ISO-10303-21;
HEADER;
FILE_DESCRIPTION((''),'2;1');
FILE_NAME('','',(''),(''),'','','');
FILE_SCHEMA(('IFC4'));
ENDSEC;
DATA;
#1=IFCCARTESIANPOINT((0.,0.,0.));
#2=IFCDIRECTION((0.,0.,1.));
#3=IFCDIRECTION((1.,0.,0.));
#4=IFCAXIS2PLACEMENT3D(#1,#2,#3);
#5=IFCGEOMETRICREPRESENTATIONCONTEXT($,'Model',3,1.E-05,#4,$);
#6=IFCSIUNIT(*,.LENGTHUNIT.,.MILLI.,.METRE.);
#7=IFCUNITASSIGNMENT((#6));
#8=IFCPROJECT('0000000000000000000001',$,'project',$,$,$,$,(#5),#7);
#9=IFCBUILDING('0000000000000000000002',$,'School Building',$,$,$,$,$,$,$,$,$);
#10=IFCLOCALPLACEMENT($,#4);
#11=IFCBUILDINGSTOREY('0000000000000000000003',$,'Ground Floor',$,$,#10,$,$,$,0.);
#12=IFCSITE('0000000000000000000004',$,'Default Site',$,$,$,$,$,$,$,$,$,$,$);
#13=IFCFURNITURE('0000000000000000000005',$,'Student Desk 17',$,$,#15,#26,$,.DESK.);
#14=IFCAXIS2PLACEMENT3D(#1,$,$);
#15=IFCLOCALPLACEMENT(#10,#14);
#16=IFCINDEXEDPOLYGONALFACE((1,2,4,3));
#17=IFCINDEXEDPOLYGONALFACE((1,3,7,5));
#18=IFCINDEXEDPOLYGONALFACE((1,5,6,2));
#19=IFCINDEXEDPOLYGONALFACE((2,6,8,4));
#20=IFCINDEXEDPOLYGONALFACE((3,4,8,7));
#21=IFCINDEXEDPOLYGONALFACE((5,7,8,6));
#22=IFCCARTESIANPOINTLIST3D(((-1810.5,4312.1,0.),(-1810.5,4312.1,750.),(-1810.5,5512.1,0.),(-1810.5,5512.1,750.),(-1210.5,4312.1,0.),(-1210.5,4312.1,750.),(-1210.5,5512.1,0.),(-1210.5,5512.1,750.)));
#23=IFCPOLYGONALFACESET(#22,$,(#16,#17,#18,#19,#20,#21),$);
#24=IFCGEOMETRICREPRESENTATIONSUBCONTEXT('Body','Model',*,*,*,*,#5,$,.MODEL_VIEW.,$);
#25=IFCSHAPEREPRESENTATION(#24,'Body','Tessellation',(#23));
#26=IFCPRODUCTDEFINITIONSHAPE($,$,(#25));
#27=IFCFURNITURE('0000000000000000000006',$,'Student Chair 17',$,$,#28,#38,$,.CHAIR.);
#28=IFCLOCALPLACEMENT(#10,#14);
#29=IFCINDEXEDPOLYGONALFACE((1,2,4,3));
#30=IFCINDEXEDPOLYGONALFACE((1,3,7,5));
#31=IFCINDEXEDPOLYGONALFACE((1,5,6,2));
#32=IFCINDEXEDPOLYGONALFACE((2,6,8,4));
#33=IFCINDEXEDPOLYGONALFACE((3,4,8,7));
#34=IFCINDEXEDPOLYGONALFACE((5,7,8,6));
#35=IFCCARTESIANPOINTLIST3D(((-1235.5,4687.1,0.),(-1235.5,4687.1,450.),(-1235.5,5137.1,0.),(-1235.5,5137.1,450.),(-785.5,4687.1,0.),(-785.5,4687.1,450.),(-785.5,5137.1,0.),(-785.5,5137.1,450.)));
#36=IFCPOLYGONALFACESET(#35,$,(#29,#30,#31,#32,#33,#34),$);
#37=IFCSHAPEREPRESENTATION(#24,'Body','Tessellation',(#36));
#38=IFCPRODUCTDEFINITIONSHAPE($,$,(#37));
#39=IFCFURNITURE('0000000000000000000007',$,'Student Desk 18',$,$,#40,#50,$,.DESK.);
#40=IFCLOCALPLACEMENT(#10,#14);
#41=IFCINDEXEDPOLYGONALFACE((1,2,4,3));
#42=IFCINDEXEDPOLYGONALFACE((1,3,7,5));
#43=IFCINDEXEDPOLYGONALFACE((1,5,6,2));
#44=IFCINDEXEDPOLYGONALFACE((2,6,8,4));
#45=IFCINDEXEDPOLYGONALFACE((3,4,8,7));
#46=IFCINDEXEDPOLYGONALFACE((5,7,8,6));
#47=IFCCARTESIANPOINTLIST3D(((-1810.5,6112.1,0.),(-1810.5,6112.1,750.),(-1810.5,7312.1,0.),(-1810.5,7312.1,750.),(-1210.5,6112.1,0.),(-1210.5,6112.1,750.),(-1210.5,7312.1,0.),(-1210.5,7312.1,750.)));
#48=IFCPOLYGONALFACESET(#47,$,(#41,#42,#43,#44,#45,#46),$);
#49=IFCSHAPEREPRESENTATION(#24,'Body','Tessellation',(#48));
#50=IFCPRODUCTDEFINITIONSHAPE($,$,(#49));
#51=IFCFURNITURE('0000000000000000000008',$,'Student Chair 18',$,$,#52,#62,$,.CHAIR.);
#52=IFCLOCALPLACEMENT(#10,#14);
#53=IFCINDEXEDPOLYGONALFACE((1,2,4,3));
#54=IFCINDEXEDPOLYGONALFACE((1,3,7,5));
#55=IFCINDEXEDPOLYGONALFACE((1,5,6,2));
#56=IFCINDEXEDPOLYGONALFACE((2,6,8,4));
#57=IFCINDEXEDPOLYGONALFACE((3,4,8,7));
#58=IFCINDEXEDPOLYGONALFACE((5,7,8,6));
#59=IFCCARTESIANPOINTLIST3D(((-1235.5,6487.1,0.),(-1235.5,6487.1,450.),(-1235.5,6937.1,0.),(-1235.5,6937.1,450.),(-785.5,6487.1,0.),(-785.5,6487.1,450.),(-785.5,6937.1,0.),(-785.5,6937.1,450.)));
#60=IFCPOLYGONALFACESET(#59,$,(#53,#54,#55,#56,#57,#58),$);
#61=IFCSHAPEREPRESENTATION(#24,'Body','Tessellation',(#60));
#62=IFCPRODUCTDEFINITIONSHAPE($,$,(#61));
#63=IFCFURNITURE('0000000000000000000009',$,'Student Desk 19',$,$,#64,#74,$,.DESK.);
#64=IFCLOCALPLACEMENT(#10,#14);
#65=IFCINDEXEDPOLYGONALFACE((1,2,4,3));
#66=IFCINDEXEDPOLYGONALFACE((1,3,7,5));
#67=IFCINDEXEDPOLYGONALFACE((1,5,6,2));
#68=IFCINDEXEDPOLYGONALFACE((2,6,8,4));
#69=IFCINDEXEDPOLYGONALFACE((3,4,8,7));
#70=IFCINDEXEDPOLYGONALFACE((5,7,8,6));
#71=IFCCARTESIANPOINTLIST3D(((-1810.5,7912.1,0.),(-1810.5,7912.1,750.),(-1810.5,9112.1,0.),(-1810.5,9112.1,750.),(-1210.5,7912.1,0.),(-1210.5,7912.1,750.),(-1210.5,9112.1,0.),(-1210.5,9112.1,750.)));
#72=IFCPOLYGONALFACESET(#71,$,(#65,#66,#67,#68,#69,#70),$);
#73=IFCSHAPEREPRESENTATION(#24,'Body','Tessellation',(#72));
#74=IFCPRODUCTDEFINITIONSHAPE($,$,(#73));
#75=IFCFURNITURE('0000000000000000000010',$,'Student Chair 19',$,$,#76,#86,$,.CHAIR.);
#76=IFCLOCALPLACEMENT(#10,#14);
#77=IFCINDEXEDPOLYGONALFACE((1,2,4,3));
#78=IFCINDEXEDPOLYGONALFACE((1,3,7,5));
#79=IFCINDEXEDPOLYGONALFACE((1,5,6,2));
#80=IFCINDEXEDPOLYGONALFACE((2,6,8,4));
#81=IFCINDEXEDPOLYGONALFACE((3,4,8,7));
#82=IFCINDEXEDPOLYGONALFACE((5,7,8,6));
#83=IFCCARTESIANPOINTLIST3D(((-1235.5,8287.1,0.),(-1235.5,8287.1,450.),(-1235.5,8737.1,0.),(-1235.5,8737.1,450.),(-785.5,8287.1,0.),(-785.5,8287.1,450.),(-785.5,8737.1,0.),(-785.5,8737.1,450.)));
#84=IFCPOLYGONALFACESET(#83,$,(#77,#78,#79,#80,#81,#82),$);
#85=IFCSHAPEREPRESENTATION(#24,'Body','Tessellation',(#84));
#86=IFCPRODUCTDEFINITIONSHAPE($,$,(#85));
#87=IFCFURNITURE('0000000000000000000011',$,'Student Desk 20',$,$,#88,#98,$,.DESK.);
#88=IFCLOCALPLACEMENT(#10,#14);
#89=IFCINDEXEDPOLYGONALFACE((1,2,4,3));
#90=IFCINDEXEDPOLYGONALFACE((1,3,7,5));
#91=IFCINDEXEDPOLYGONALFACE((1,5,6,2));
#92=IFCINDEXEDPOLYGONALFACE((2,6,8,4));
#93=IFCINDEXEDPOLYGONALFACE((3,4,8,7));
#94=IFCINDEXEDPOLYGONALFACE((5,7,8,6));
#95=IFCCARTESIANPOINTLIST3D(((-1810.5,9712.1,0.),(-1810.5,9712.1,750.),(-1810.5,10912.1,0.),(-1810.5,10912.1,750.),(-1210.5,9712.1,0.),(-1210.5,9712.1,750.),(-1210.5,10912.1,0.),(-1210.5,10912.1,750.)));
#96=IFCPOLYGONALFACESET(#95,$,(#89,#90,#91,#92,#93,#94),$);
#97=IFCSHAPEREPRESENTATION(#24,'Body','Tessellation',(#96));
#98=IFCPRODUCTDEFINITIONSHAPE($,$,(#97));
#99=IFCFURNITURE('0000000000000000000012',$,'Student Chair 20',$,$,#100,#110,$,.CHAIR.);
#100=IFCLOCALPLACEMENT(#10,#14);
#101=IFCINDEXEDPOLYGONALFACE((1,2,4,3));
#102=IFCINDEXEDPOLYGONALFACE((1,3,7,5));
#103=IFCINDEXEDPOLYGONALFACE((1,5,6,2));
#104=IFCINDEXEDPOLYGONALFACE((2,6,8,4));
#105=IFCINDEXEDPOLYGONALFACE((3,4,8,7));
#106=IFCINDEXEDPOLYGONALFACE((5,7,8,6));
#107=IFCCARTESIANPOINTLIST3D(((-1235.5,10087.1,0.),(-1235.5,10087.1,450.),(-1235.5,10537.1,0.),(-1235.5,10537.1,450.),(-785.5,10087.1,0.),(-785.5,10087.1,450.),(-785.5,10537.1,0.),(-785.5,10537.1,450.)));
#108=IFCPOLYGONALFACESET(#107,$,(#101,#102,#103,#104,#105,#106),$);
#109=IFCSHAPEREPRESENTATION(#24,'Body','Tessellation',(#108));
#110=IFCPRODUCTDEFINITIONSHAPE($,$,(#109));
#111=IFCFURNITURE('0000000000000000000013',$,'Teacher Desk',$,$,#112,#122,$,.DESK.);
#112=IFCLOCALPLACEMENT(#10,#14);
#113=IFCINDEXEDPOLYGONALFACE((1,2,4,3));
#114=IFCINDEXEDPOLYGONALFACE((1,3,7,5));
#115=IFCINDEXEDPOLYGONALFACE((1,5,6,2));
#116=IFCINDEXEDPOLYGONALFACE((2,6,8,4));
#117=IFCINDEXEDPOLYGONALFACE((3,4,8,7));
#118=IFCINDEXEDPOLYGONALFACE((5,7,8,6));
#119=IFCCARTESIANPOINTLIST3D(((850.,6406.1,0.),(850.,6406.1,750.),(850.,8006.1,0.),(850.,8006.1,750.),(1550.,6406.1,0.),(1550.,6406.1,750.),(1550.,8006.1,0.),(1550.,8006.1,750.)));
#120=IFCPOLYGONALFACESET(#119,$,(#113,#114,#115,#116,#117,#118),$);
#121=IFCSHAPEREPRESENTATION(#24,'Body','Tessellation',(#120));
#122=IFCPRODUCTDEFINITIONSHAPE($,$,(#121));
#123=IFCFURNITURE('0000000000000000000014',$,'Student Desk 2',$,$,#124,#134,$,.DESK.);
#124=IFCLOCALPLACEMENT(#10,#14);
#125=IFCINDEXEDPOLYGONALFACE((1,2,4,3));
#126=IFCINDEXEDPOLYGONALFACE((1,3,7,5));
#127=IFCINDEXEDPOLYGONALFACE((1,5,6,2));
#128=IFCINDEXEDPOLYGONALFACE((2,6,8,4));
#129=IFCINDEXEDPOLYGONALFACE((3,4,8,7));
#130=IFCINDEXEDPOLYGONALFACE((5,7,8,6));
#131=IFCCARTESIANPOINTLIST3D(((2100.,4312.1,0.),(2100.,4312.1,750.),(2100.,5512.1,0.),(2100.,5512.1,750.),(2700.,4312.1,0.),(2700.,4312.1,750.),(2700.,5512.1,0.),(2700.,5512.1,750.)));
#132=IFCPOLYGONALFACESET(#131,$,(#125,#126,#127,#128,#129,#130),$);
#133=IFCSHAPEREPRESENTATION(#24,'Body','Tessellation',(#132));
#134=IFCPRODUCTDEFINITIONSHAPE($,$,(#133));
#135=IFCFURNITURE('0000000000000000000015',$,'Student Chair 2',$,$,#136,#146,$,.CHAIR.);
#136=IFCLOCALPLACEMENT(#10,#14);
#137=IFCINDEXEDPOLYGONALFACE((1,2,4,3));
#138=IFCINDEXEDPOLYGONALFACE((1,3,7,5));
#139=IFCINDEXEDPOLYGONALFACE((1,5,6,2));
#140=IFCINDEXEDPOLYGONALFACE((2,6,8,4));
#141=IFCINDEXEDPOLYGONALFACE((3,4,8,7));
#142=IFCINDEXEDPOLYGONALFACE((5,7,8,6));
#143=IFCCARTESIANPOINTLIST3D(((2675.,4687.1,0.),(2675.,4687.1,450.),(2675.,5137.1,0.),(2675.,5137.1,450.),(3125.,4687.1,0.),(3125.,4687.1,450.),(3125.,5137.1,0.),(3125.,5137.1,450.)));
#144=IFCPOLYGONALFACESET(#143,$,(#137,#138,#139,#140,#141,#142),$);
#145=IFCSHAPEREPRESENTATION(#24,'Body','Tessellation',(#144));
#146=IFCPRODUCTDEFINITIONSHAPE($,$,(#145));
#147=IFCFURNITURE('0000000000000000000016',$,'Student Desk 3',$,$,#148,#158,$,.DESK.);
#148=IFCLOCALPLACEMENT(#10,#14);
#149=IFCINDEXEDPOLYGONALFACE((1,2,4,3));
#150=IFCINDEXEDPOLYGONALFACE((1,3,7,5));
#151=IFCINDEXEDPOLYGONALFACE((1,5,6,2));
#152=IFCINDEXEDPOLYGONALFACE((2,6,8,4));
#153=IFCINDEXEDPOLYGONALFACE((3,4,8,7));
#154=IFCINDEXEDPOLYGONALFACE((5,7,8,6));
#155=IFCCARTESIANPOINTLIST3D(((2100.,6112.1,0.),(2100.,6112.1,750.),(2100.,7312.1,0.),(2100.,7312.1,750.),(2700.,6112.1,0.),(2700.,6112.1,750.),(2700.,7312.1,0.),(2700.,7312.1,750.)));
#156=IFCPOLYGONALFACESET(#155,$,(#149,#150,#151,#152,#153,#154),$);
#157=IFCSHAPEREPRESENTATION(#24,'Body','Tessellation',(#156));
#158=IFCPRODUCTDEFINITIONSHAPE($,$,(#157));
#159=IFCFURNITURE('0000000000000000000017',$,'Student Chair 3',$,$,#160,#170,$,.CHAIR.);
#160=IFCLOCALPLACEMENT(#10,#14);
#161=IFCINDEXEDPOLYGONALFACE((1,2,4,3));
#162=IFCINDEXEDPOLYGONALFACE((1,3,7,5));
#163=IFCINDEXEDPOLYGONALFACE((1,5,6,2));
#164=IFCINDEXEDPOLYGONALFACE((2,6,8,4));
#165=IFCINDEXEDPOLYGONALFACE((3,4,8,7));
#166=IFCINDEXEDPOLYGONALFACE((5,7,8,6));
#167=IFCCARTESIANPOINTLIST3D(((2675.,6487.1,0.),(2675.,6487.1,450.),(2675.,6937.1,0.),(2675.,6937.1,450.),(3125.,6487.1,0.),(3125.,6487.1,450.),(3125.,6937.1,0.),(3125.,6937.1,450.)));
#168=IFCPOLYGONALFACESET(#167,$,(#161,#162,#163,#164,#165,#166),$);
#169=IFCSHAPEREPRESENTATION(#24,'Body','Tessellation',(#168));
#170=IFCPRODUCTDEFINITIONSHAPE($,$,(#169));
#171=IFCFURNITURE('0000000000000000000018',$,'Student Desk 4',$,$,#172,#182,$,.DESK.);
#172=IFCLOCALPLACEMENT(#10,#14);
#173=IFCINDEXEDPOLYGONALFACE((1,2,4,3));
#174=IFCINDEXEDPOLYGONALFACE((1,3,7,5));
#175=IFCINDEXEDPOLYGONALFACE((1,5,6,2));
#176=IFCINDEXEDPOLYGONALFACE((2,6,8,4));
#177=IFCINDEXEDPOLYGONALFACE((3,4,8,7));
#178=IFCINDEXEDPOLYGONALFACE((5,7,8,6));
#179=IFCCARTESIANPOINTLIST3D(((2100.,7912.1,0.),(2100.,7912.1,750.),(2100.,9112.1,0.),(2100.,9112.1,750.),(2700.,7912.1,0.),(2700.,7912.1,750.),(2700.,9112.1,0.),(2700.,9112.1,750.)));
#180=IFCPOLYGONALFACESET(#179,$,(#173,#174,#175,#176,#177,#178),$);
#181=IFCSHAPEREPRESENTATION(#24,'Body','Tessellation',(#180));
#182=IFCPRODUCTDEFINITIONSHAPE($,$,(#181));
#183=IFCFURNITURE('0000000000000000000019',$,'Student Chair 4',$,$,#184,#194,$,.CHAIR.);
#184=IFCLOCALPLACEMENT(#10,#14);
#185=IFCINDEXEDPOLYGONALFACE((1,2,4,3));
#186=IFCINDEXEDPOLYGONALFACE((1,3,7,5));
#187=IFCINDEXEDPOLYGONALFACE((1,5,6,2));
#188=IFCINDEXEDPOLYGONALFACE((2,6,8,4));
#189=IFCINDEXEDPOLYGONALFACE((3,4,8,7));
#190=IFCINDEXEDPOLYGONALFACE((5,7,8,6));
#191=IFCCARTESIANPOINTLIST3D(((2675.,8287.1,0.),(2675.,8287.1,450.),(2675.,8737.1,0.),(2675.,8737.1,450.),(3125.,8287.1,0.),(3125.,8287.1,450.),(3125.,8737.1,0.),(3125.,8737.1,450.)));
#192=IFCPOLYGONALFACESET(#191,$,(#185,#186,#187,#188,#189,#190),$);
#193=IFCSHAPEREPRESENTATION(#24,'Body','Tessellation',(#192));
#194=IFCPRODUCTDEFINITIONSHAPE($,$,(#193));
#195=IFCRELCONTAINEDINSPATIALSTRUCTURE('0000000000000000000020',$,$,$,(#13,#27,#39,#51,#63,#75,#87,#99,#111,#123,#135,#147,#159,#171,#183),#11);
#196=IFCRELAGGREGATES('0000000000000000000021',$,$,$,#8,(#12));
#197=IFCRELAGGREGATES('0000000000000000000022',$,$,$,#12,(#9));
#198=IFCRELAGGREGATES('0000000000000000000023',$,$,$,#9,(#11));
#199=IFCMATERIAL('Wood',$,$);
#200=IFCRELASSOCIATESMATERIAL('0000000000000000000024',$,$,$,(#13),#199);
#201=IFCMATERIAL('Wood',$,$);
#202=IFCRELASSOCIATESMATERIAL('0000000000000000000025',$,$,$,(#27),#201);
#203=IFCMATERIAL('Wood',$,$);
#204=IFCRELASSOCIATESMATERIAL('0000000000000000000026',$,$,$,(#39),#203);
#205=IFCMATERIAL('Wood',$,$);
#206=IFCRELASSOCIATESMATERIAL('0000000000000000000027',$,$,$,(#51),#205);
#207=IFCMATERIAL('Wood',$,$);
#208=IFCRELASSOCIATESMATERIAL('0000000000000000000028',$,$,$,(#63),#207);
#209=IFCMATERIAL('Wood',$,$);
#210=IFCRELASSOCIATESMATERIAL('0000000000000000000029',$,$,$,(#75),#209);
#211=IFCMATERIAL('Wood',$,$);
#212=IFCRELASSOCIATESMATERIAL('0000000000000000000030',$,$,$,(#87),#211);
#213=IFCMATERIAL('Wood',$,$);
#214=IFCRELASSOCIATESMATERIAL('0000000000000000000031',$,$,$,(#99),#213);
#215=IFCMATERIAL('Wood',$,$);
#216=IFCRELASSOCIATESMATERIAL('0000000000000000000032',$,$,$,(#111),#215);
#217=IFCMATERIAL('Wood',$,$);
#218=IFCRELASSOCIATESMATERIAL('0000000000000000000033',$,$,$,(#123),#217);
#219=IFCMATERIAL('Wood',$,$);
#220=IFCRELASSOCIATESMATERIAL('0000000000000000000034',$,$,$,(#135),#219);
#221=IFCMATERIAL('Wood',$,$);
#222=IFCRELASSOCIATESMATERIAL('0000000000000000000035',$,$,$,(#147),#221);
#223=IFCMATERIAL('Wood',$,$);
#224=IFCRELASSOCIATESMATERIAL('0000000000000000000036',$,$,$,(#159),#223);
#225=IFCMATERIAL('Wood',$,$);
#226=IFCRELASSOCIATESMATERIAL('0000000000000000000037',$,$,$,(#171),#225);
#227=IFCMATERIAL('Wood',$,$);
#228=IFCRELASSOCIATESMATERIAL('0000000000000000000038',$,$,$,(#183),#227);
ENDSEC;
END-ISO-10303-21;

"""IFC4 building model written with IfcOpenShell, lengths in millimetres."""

from ifc_helpers import new_model, si_unit, frame, origin_with_axes, origin_2d, place, context, subcontext, project, spatial, rectangle, extrude, material, element, save


model = new_model("IFC4")

# Units and contexts
model_context = context("Model", 3, precision=1e-05, world=origin_with_axes())
body_context = subcontext(model_context, "Body", "Model", "MODEL_VIEW")
ifc_project = project(units=[si_unit("LENGTHUNIT", "METRE", prefix="MILLI")], contexts=[model_context])

# Site, building, storey
site = spatial("IfcSite", under=ifc_project, Name="Default Site")
building = spatial("IfcBuilding", under=site, Name="School Building")
storey_placement = place(None, origin_with_axes())
storey = spatial("IfcBuildingStorey", under=building, at=storey_placement, Name="Ground Floor", Elevation=0.0)

# Furniture
ifc_material_1 = material(Name="Wood")
furniture_1_placement = place(storey_placement, frame((-1510.5, 4912.1, 0.0), z_axis=(0.0, 0.0, 1.0), x_axis=(0.0, 1.0, 0.0)))
element("IfcFurniture", 1, at=furniture_1_placement, inside=storey, material=ifc_material_1, Name="Student Desk 17", PredefinedType="DESK", context=body_context, shape_type="SweptSolid", body=[
    extrude(rectangle(XDim=1200.0, YDim=600.0, at=origin_2d()), origin_with_axes(), (0.0, 0.0, 1.0), 750.0),
])
ifc_material_2 = material(Name="Wood")
furniture_2_placement = place(storey_placement, frame((-1010.5, 4912.1, 0.0), z_axis=(0.0, 0.0, 1.0), x_axis=(1.0, 0.0, 0.0)))
element("IfcFurniture", 2, at=furniture_2_placement, inside=storey, material=ifc_material_2, Name="Student Chair 17", PredefinedType="CHAIR", context=body_context, shape_type="SweptSolid", body=[
    extrude(rectangle(XDim=450.0, YDim=450.0, at=origin_2d()), origin_with_axes(), (0.0, 0.0, 1.0), 450.0),
])
ifc_material_3 = material(Name="Wood")
furniture_3_placement = place(storey_placement, frame((-1510.5, 6712.1, 0.0), z_axis=(0.0, 0.0, 1.0), x_axis=(0.0, 1.0, 0.0)))
element("IfcFurniture", 3, at=furniture_3_placement, inside=storey, material=ifc_material_3, Name="Student Desk 18", PredefinedType="DESK", context=body_context, shape_type="SweptSolid", body=[
    extrude(rectangle(XDim=1200.0, YDim=600.0, at=origin_2d()), origin_with_axes(), (0.0, 0.0, 1.0), 750.0),
])
ifc_material_4 = material(Name="Wood")
furniture_4_placement = place(storey_placement, frame((-1010.5, 6712.1, 0.0), z_axis=(0.0, 0.0, 1.0), x_axis=(1.0, 0.0, 0.0)))
element("IfcFurniture", 4, at=furniture_4_placement, inside=storey, material=ifc_material_4, Name="Student Chair 18", PredefinedType="CHAIR", context=body_context, shape_type="SweptSolid", body=[
    extrude(rectangle(XDim=450.0, YDim=450.0, at=origin_2d()), origin_with_axes(), (0.0, 0.0, 1.0), 450.0),
])
ifc_material_5 = material(Name="Wood")
furniture_5_placement = place(storey_placement, frame((-1510.5, 8512.1, 0.0), z_axis=(0.0, 0.0, 1.0), x_axis=(0.0, 1.0, 0.0)))
element("IfcFurniture", 5, at=furniture_5_placement, inside=storey, material=ifc_material_5, Name="Student Desk 19", PredefinedType="DESK", context=body_context, shape_type="SweptSolid", body=[
    extrude(rectangle(XDim=1200.0, YDim=600.0, at=origin_2d()), origin_with_axes(), (0.0, 0.0, 1.0), 750.0),
])
ifc_material_6 = material(Name="Wood")
furniture_6_placement = place(storey_placement, frame((-1010.5, 8512.1, 0.0), z_axis=(0.0, 0.0, 1.0), x_axis=(1.0, 0.0, 0.0)))
element("IfcFurniture", 6, at=furniture_6_placement, inside=storey, material=ifc_material_6, Name="Student Chair 19", PredefinedType="CHAIR", context=body_context, shape_type="SweptSolid", body=[
    extrude(rectangle(XDim=450.0, YDim=450.0, at=origin_2d()), origin_with_axes(), (0.0, 0.0, 1.0), 450.0),
])
ifc_material_7 = material(Name="Wood")
furniture_7_placement = place(storey_placement, frame((-1510.5, 10312.1, 0.0), z_axis=(0.0, 0.0, 1.0), x_axis=(0.0, 1.0, 0.0)))
element("IfcFurniture", 7, at=furniture_7_placement, inside=storey, material=ifc_material_7, Name="Student Desk 20", PredefinedType="DESK", context=body_context, shape_type="SweptSolid", body=[
    extrude(rectangle(XDim=1200.0, YDim=600.0, at=origin_2d()), origin_with_axes(), (0.0, 0.0, 1.0), 750.0),
])
ifc_material_8 = material(Name="Wood")
furniture_8_placement = place(storey_placement, frame((-1010.5, 10312.1, 0.0), z_axis=(0.0, 0.0, 1.0), x_axis=(1.0, 0.0, 0.0)))
element("IfcFurniture", 8, at=furniture_8_placement, inside=storey, material=ifc_material_8, Name="Student Chair 20", PredefinedType="CHAIR", context=body_context, shape_type="SweptSolid", body=[
    extrude(rectangle(XDim=450.0, YDim=450.0, at=origin_2d()), origin_with_axes(), (0.0, 0.0, 1.0), 450.0),
])
ifc_material_9 = material(Name="Wood")
furniture_9_placement = place(storey_placement, frame((1200.0, 7206.1, 0.0), z_axis=(0.0, 0.0, 1.0), x_axis=(0.0, 1.0, 0.0)))
element("IfcFurniture", 9, at=furniture_9_placement, inside=storey, material=ifc_material_9, Name="Teacher Desk", PredefinedType="DESK", context=body_context, shape_type="SweptSolid", body=[
    extrude(rectangle(XDim=1600.0, YDim=700.0, at=origin_2d()), origin_with_axes(), (0.0, 0.0, 1.0), 750.0),
])
ifc_material_10 = material(Name="Wood")
furniture_10_placement = place(storey_placement, frame((2400.0, 4912.1, 0.0), z_axis=(0.0, 0.0, 1.0), x_axis=(0.0, 1.0, 0.0)))
element("IfcFurniture", 10, at=furniture_10_placement, inside=storey, material=ifc_material_10, Name="Student Desk 2", PredefinedType="DESK", context=body_context, shape_type="SweptSolid", body=[
    extrude(rectangle(XDim=1200.0, YDim=600.0, at=origin_2d()), origin_with_axes(), (0.0, 0.0, 1.0), 750.0),
])
ifc_material_11 = material(Name="Wood")
furniture_11_placement = place(storey_placement, frame((2900.0, 4912.1, 0.0), z_axis=(0.0, 0.0, 1.0), x_axis=(1.0, 0.0, 0.0)))
element("IfcFurniture", 11, at=furniture_11_placement, inside=storey, material=ifc_material_11, Name="Student Chair 2", PredefinedType="CHAIR", context=body_context, shape_type="SweptSolid", body=[
    extrude(rectangle(XDim=450.0, YDim=450.0, at=origin_2d()), origin_with_axes(), (0.0, 0.0, 1.0), 450.0),
])
ifc_material_12 = material(Name="Wood")
furniture_12_placement = place(storey_placement, frame((2400.0, 6712.1, 0.0), z_axis=(0.0, 0.0, 1.0), x_axis=(0.0, 1.0, 0.0)))
element("IfcFurniture", 12, at=furniture_12_placement, inside=storey, material=ifc_material_12, Name="Student Desk 3", PredefinedType="DESK", context=body_context, shape_type="SweptSolid", body=[
    extrude(rectangle(XDim=1200.0, YDim=600.0, at=origin_2d()), origin_with_axes(), (0.0, 0.0, 1.0), 750.0),
])
ifc_material_13 = material(Name="Wood")
furniture_13_placement = place(storey_placement, frame((2900.0, 6712.1, 0.0), z_axis=(0.0, 0.0, 1.0), x_axis=(1.0, 0.0, 0.0)))
element("IfcFurniture", 13, at=furniture_13_placement, inside=storey, material=ifc_material_13, Name="Student Chair 3", PredefinedType="CHAIR", context=body_context, shape_type="SweptSolid", body=[
    extrude(rectangle(XDim=450.0, YDim=450.0, at=origin_2d()), origin_with_axes(), (0.0, 0.0, 1.0), 450.0),
])
ifc_material_14 = material(Name="Wood")
furniture_14_placement = place(storey_placement, frame((2400.0, 8512.1, 0.0), z_axis=(0.0, 0.0, 1.0), x_axis=(0.0, 1.0, 0.0)))
element("IfcFurniture", 14, at=furniture_14_placement, inside=storey, material=ifc_material_14, Name="Student Desk 4", PredefinedType="DESK", context=body_context, shape_type="SweptSolid", body=[
    extrude(rectangle(XDim=1200.0, YDim=600.0, at=origin_2d()), origin_with_axes(), (0.0, 0.0, 1.0), 750.0),
])
ifc_material_15 = material(Name="Wood")
furniture_15_placement = place(storey_placement, frame((2900.0, 8512.1, 0.0), z_axis=(0.0, 0.0, 1.0), x_axis=(1.0, 0.0, 0.0)))
element("IfcFurniture", 15, at=furniture_15_placement, inside=storey, material=ifc_material_15, Name="Student Chair 4", PredefinedType="CHAIR", context=body_context, shape_type="SweptSolid", body=[
    extrude(rectangle(XDim=450.0, YDim=450.0, at=origin_2d()), origin_with_axes(), (0.0, 0.0, 1.0), 450.0),
])

save(model, "model.ifc")
